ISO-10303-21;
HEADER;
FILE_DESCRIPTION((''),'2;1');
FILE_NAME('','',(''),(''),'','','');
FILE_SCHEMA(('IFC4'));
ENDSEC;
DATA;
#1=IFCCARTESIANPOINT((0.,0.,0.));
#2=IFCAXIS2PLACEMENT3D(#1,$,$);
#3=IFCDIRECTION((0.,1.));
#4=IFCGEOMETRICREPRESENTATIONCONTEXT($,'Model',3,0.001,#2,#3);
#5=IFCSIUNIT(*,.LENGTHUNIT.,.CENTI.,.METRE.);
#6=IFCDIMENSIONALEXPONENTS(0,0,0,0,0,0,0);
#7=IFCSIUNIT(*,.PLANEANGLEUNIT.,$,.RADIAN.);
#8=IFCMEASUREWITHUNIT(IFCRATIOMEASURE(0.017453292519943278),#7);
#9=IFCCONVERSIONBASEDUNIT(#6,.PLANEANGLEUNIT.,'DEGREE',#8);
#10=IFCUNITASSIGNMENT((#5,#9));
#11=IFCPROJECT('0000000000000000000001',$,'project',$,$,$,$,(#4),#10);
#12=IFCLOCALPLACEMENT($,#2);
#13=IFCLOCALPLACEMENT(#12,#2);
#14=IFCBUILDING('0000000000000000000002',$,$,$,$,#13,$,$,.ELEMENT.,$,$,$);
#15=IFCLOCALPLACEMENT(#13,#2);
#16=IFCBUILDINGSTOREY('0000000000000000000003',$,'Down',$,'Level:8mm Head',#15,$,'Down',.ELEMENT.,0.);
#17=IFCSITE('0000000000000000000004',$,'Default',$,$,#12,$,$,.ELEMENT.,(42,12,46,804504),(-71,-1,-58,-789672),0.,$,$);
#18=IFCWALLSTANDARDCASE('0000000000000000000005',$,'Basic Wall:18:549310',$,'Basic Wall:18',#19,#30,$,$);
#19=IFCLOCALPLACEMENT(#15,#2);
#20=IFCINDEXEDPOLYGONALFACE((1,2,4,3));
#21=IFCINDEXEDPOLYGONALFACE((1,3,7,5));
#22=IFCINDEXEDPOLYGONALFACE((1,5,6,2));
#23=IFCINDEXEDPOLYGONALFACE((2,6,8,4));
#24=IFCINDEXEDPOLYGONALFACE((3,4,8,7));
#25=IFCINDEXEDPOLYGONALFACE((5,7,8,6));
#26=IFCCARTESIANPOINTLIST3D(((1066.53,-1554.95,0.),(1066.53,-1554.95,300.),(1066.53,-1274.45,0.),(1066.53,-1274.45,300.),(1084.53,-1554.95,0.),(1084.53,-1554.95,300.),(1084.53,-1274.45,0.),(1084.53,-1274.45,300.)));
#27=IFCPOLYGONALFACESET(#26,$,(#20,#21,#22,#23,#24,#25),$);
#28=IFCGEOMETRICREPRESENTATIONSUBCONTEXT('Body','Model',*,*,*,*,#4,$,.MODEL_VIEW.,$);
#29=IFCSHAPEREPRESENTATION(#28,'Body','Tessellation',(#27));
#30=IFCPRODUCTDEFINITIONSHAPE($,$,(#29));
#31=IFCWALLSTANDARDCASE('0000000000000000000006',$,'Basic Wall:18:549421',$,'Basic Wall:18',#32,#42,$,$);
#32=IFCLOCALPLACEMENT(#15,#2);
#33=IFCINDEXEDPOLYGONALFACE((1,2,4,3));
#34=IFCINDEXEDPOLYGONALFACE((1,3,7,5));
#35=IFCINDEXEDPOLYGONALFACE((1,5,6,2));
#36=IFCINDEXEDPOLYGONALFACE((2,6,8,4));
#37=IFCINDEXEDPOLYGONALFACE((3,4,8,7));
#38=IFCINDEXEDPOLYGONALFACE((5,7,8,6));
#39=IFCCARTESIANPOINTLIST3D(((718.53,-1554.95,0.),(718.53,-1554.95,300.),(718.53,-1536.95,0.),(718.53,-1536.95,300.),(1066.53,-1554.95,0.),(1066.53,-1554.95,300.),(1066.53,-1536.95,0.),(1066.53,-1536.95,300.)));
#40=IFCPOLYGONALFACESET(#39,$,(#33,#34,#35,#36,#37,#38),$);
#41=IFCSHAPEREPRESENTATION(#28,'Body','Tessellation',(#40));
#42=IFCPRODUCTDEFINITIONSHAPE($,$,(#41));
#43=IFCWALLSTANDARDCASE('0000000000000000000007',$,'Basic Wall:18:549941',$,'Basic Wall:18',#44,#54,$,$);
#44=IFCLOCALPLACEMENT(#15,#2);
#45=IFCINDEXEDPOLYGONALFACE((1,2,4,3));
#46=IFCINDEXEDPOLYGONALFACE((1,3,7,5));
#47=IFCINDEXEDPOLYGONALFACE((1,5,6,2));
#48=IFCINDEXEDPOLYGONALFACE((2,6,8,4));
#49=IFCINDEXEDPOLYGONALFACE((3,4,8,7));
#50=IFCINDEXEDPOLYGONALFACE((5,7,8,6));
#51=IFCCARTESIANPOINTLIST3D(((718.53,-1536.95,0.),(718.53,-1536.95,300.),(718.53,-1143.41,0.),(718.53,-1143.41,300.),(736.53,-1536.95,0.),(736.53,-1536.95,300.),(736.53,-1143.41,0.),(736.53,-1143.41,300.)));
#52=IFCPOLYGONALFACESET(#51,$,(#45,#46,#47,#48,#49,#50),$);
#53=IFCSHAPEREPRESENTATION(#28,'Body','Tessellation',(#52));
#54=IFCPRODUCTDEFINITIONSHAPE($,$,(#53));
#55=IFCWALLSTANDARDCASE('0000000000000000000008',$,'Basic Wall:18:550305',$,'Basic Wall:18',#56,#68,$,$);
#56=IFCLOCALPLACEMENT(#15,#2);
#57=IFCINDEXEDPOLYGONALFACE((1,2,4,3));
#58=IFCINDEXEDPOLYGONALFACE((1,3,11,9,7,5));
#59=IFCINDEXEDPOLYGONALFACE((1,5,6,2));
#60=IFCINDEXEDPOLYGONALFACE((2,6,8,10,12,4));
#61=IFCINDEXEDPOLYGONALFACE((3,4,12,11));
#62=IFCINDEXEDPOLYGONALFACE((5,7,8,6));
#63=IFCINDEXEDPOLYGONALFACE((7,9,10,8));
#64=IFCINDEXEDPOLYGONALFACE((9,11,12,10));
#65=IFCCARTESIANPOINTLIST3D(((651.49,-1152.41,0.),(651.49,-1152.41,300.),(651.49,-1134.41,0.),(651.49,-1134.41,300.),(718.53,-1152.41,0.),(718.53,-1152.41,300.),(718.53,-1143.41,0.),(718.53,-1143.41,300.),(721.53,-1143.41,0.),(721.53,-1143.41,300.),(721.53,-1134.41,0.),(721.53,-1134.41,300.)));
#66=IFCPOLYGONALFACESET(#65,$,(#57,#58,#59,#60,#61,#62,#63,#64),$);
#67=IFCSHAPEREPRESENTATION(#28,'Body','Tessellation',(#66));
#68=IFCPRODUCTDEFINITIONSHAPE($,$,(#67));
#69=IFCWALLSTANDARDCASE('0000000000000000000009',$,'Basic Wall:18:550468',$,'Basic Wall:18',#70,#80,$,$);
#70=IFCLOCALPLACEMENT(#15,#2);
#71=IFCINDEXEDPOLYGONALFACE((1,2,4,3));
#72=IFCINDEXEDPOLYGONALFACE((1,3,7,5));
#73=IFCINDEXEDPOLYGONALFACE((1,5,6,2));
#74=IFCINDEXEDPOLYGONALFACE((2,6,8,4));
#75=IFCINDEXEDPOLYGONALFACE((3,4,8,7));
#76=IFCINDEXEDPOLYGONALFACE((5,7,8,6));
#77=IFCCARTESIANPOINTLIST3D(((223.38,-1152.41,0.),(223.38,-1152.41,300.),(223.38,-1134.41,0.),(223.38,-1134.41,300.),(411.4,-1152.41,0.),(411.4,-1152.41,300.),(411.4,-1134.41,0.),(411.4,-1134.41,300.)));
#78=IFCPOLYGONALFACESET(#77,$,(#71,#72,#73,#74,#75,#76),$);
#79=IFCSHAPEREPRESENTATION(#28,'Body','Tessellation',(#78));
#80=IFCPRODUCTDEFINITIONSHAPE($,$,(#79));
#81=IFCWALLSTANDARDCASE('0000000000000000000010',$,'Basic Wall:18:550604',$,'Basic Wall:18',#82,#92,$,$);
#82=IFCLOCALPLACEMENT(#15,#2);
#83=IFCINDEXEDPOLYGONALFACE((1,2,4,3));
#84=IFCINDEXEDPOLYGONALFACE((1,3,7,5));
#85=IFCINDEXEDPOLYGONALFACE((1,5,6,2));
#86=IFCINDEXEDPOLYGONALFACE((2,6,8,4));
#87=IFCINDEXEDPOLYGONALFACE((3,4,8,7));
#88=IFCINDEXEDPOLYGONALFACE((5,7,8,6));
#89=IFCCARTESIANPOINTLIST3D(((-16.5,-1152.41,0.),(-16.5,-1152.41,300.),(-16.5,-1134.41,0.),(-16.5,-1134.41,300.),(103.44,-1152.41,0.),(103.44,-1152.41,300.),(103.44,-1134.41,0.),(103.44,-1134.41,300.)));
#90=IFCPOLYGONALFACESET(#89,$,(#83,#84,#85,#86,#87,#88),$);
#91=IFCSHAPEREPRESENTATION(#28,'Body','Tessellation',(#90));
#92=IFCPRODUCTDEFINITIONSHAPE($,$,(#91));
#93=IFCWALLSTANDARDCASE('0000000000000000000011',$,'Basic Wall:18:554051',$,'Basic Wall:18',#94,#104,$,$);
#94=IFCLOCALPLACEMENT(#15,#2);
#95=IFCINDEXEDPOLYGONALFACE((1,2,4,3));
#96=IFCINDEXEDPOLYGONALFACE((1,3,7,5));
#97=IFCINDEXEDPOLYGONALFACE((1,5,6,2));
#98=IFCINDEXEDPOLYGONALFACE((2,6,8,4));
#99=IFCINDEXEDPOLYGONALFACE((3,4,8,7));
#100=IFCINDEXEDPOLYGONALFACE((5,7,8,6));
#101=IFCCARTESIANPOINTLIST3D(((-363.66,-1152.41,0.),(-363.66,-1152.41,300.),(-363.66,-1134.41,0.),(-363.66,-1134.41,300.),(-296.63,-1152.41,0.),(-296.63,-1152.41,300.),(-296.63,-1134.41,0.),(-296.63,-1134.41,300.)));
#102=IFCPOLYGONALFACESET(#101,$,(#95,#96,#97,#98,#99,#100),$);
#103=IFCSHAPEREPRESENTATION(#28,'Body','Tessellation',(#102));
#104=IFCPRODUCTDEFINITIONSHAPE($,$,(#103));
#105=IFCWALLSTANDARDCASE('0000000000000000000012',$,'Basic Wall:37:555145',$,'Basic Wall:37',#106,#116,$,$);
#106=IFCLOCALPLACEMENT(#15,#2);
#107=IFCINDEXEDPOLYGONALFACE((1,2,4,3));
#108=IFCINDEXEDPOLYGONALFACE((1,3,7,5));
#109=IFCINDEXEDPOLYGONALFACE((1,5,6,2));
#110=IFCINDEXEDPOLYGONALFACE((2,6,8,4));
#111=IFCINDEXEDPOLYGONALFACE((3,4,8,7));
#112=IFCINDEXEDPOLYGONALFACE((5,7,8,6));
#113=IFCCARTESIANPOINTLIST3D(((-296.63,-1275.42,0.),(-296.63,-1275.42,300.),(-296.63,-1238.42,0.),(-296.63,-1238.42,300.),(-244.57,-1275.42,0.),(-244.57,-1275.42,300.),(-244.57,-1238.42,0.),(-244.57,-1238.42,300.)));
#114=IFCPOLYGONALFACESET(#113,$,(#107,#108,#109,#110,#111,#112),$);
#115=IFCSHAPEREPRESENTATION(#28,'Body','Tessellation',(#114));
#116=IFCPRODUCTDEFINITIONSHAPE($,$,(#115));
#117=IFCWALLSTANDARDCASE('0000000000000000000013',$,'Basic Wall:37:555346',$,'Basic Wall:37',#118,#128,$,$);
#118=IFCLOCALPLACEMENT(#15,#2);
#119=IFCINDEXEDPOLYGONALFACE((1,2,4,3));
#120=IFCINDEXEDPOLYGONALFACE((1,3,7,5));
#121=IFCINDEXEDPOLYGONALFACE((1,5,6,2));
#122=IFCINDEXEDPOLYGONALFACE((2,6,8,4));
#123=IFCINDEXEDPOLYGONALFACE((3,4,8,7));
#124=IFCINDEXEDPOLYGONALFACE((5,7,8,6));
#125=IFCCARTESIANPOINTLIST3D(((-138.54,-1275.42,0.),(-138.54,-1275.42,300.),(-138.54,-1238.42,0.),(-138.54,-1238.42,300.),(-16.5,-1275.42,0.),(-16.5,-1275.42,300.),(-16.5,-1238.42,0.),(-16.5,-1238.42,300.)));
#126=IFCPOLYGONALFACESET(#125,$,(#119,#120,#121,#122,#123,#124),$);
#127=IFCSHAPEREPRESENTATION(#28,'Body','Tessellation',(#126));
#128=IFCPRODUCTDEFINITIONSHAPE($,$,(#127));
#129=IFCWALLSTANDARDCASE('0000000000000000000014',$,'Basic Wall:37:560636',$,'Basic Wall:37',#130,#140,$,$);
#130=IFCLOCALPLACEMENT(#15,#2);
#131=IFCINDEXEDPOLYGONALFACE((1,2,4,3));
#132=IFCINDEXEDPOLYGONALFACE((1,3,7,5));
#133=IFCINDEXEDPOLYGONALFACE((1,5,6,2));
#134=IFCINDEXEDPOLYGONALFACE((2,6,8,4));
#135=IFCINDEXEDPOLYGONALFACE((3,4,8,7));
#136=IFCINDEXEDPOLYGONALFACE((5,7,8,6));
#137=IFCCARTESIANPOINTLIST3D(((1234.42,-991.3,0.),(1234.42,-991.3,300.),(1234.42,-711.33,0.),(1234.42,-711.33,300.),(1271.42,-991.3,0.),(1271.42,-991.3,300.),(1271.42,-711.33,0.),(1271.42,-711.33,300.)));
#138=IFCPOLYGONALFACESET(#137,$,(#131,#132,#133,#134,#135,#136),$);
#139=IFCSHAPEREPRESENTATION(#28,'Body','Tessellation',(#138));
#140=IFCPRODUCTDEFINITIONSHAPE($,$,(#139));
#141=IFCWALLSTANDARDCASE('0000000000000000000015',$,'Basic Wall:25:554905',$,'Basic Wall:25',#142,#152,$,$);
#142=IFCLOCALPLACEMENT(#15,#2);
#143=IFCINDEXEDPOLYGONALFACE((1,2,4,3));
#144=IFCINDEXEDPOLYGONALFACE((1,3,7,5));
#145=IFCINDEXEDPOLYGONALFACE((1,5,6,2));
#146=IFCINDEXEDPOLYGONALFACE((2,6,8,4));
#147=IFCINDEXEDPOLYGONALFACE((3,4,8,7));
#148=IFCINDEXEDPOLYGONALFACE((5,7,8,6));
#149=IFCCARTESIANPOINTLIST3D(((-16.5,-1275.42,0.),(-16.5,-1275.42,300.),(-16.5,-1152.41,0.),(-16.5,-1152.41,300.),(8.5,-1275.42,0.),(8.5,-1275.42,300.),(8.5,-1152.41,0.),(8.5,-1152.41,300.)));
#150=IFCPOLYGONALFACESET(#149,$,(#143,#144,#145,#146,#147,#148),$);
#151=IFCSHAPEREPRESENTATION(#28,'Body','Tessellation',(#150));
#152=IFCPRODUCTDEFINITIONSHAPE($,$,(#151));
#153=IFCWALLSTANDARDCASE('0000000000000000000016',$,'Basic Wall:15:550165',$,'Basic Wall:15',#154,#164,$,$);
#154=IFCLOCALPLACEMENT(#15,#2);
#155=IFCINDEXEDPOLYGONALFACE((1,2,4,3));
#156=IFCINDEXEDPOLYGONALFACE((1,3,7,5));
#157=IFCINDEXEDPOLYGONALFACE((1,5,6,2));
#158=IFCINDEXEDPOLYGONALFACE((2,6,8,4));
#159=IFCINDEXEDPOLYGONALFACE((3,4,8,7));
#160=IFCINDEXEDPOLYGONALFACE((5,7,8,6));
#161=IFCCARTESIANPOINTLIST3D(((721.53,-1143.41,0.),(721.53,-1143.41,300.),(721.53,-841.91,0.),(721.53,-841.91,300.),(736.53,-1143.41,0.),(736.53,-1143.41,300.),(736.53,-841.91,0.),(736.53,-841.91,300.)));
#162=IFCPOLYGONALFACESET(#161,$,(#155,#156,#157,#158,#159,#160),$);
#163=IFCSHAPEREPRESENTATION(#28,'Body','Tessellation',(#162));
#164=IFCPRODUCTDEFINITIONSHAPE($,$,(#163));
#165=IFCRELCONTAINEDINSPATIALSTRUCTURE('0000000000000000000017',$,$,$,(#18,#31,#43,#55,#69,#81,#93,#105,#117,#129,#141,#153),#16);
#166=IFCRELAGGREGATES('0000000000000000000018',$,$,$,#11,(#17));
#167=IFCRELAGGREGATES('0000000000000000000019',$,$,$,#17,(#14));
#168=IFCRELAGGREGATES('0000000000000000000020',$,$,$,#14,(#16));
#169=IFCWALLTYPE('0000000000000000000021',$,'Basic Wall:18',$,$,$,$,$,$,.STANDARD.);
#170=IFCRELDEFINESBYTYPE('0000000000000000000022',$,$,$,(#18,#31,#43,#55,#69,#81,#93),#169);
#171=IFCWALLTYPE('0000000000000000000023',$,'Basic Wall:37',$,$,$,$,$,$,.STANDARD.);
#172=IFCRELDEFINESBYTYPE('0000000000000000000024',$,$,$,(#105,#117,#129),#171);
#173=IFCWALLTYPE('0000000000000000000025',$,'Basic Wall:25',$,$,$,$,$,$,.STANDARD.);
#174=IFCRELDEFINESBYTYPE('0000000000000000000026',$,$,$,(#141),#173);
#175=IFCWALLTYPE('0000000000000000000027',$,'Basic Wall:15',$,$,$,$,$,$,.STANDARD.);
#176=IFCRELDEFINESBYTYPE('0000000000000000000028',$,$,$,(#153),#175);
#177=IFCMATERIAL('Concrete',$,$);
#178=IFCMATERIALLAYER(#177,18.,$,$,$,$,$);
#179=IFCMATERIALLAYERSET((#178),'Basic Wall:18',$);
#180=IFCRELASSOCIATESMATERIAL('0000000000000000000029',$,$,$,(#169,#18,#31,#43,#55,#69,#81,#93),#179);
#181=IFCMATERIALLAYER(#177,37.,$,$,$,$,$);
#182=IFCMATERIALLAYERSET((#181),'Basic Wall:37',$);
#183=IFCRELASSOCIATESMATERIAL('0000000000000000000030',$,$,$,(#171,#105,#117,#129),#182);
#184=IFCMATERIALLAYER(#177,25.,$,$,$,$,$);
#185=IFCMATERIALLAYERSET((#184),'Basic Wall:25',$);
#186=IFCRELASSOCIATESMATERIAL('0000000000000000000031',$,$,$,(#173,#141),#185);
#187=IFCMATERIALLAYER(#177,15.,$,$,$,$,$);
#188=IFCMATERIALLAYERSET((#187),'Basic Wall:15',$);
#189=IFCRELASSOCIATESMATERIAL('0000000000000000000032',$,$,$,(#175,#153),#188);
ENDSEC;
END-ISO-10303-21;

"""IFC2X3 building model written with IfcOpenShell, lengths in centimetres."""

from ifc_helpers import new_model, entity, si_unit, converted_unit, direction, frame, frame_2d, origin, place, context, subcontext, project, spatial, polyline, rectangle, outline, extrude, material, layer, layer_set, layer_usage, type_object, element, save


model = new_model("IFC2X3")

# Units and contexts
model_context = context("Model", 3, precision=0.001, world=origin(), true_north=direction((0.0, 1.0)))
body_context = subcontext(model_context, "Body", "Model", "MODEL_VIEW")
ifc_project = project(units=[si_unit("LENGTHUNIT", "METRE", prefix="CENTI"), converted_unit("PLANEANGLEUNIT", "DEGREE", entity("IfcRatioMeasure", 0.017453292519943278), si_unit("PLANEANGLEUNIT", "RADIAN"), dimensions=[0, 0, 0, 0, 0, 0, 0])], contexts=[model_context])

# Site, building, storey
site_placement = place(None, origin())
site = spatial("IfcSite", under=ifc_project, at=site_placement, Name="Default", CompositionType="ELEMENT", RefLatitude=(42, 12, 46, 804504), RefLongitude=(-71, -1, -58, -789672), RefElevation=0.0)
building_placement = place(site_placement, origin())
building = spatial("IfcBuilding", under=site, at=building_placement, CompositionType="ELEMENT")
storey_placement = place(building_placement, origin())
storey = spatial("IfcBuildingStorey", under=building, at=storey_placement, Name="Down", ObjectType="Level:8mm Head", LongName="Down", CompositionType="ELEMENT", Elevation=0.0)

# Walls
ifc_material = material(Name="Concrete")
ifc_layer_1 = layer(ifc_material, 18.0)
ifc_layer_set_1 = layer_set([ifc_layer_1], Name="Basic Wall:18")
wall_type_1 = type_object("IfcWallType", Name="Basic Wall:18", PredefinedType="STANDARD", material=ifc_layer_set_1)
ifc_layer_usage_1 = layer_usage(ifc_layer_set_1, "AXIS2", "POSITIVE", -9.0)
wall_1_placement = place(storey_placement, frame((1075.53, -1274.45, 0.0), z_axis=(0.0, 0.0, 1.0), x_axis=(0.0, -1.0, 0.0)))
element("IfcWallStandardCase", 1, at=wall_1_placement, inside=storey, type_object=wall_type_1, material=ifc_layer_usage_1, Name="Basic Wall:18:549310", ObjectType="Basic Wall:18", context=body_context, shape_type="SweptSolid", body=[
    extrude(rectangle(XDim=280.5, YDim=18.0, at=frame_2d((140.25, 0.0), x_axis=(-1.0, 0.0))), origin(), (0.0, 0.0, 1.0), 300.0),
])
ifc_layer_usage_2 = layer_usage(ifc_layer_set_1, "AXIS2", "NEGATIVE", 9.0)
wall_2_placement = place(storey_placement, frame((1066.53, -1545.95, 0.0), z_axis=(0.0, 0.0, 1.0), x_axis=(-1.0, 0.0, 0.0)))
element("IfcWallStandardCase", 2, at=wall_2_placement, inside=storey, type_object=wall_type_1, material=ifc_layer_usage_2, Name="Basic Wall:18:549421", ObjectType="Basic Wall:18", context=body_context, shape_type="SweptSolid", body=[
    extrude(rectangle(XDim=348.0, YDim=18.0, at=frame_2d((174.0, 0.0), x_axis=(-1.0, 0.0))), origin(), (0.0, 0.0, 1.0), 300.0),
])
ifc_layer_usage_3 = layer_usage(ifc_layer_set_1, "AXIS2", "NEGATIVE", 9.0)
wall_3_placement = place(storey_placement, frame((727.53, -1536.95, 0.0), z_axis=(0.0, 0.0, 1.0), x_axis=(0.0, 1.0, 0.0)))
element("IfcWallStandardCase", 3, at=wall_3_placement, inside=storey, type_object=wall_type_1, material=ifc_layer_usage_3, Name="Basic Wall:18:549941", ObjectType="Basic Wall:18", context=body_context, shape_type="SweptSolid", body=[
    extrude(rectangle(XDim=393.55, YDim=18.0, at=frame_2d((196.77, 0.0), x_axis=(-1.0, 0.0))), origin(), (0.0, 0.0, 1.0), 300.0),
])
ifc_layer_usage_4 = layer_usage(ifc_layer_set_1, "AXIS2", "POSITIVE", -9.0)
wall_4_placement = place(storey_placement, frame((721.53, -1143.41, 0.0), z_axis=(0.0, 0.0, 1.0), x_axis=(-1.0, 0.0, 0.0)))
element("IfcWallStandardCase", 4, at=wall_4_placement, inside=storey, type_object=wall_type_1, material=ifc_layer_usage_4, Name="Basic Wall:18:550305", ObjectType="Basic Wall:18", context=body_context, shape_type="SweptSolid", body=[
    extrude(outline(polyline([(70.04, -9.0), (70.04, 9.0), (3.0, 9.0), (3.0, 0.0), (0.0, 0.0), (0.0, -9.0), (70.04, -9.0)])), origin(), (0.0, 0.0, 1.0), 300.0),
])
ifc_layer_usage_5 = layer_usage(ifc_layer_set_1, "AXIS2", "POSITIVE", -9.0)
wall_5_placement = place(storey_placement, frame((411.4, -1143.41, 0.0), z_axis=(0.0, 0.0, 1.0), x_axis=(-1.0, 0.0, 0.0)))
element("IfcWallStandardCase", 5, at=wall_5_placement, inside=storey, type_object=wall_type_1, material=ifc_layer_usage_5, Name="Basic Wall:18:550468", ObjectType="Basic Wall:18", context=body_context, shape_type="SweptSolid", body=[
    extrude(rectangle(XDim=188.02, YDim=18.0, at=frame_2d((94.01, 0.0), x_axis=(-1.0, 0.0))), origin(), (0.0, 0.0, 1.0), 300.0),
])
ifc_layer_usage_6 = layer_usage(ifc_layer_set_1, "AXIS2", "POSITIVE", -9.0)
wall_6_placement = place(storey_placement, frame((103.44, -1143.41, 0.0), z_axis=(0.0, 0.0, 1.0), x_axis=(-1.0, 0.0, 0.0)))
element("IfcWallStandardCase", 6, at=wall_6_placement, inside=storey, type_object=wall_type_1, material=ifc_layer_usage_6, Name="Basic Wall:18:550604", ObjectType="Basic Wall:18", context=body_context, shape_type="SweptSolid", body=[
    extrude(rectangle(XDim=119.94, YDim=18.0, at=frame_2d((59.97, 0.0), x_axis=(-1.0, 0.0))), origin(), (0.0, 0.0, 1.0), 300.0),
])
ifc_layer_usage_7 = layer_usage(ifc_layer_set_1, "AXIS2", "POSITIVE", -9.0)
wall_7_placement = place(storey_placement, frame((-296.63, -1143.41, 0.0), z_axis=(0.0, 0.0, 1.0), x_axis=(-1.0, 0.0, 0.0)))
element("IfcWallStandardCase", 7, at=wall_7_placement, inside=storey, type_object=wall_type_1, material=ifc_layer_usage_7, Name="Basic Wall:18:554051", ObjectType="Basic Wall:18", context=body_context, shape_type="SweptSolid", body=[
    extrude(rectangle(XDim=67.03, YDim=18.0, at=frame_2d((33.52, 0.0), x_axis=(-1.0, 0.0))), origin(), (0.0, 0.0, 1.0), 300.0),
])
ifc_layer_2 = layer(ifc_material, 37.0)
ifc_layer_set_2 = layer_set([ifc_layer_2], Name="Basic Wall:37")
ifc_layer_usage_8 = layer_usage(ifc_layer_set_2, "AXIS2", "POSITIVE", -18.5)
wall_type_2 = type_object("IfcWallType", Name="Basic Wall:37", PredefinedType="STANDARD", material=ifc_layer_set_2)
wall_8_placement = place(storey_placement, frame((-296.63, -1256.92, 0.0)))
element("IfcWallStandardCase", 8, at=wall_8_placement, inside=storey, type_object=wall_type_2, material=ifc_layer_usage_8, Name="Basic Wall:37:555145", ObjectType="Basic Wall:37", context=body_context, shape_type="SweptSolid", body=[
    extrude(rectangle(XDim=52.06, YDim=37.0, at=frame_2d((26.03, 0.0), x_axis=(-1.0, 0.0))), origin(), (0.0, 0.0, 1.0), 300.0),
])
ifc_layer_usage_9 = layer_usage(ifc_layer_set_2, "AXIS2", "POSITIVE", -18.5)
wall_9_placement = place(storey_placement, frame((-138.54, -1256.92, 0.0)))
element("IfcWallStandardCase", 9, at=wall_9_placement, inside=storey, type_object=wall_type_2, material=ifc_layer_usage_9, Name="Basic Wall:37:555346", ObjectType="Basic Wall:37", context=body_context, shape_type="SweptSolid", body=[
    extrude(rectangle(XDim=122.05, YDim=37.0, at=frame_2d((61.02, 0.0), x_axis=(-1.0, 0.0))), origin(), (0.0, 0.0, 1.0), 300.0),
])
ifc_layer_usage_10 = layer_usage(ifc_layer_set_2, "AXIS2", "POSITIVE", -18.5)
wall_10_placement = place(storey_placement, frame((1252.92, -991.3, 0.0), z_axis=(0.0, 0.0, 1.0), x_axis=(0.0, 1.0, 0.0)))
element("IfcWallStandardCase", 10, at=wall_10_placement, inside=storey, type_object=wall_type_2, material=ifc_layer_usage_10, Name="Basic Wall:37:560636", ObjectType="Basic Wall:37", context=body_context, shape_type="SweptSolid", body=[
    extrude(rectangle(XDim=279.98, YDim=37.0, at=frame_2d((139.99, 0.0), x_axis=(-1.0, 0.0))), origin(), (0.0, 0.0, 1.0), 300.0),
])
ifc_layer_3 = layer(ifc_material, 25.0)
ifc_layer_set_3 = layer_set([ifc_layer_3], Name="Basic Wall:25")
ifc_layer_usage_11 = layer_usage(ifc_layer_set_3, "AXIS2", "POSITIVE", -12.5)
wall_type_3 = type_object("IfcWallType", Name="Basic Wall:25", PredefinedType="STANDARD", material=ifc_layer_set_3)
wall_11_placement = place(storey_placement, frame((-4.0, -1152.41, 0.0), z_axis=(0.0, 0.0, 1.0), x_axis=(0.0, -1.0, 0.0)))
element("IfcWallStandardCase", 11, at=wall_11_placement, inside=storey, type_object=wall_type_3, material=ifc_layer_usage_11, Name="Basic Wall:25:554905", ObjectType="Basic Wall:25", context=body_context, shape_type="SweptSolid", body=[
    extrude(rectangle(XDim=123.02, YDim=25.0, at=frame_2d((61.51, 0.0), x_axis=(-1.0, 0.0))), origin(), (0.0, 0.0, 1.0), 300.0),
])
ifc_layer_4 = layer(ifc_material, 15.0)
ifc_layer_set_4 = layer_set([ifc_layer_4], Name="Basic Wall:15")
ifc_layer_usage_12 = layer_usage(ifc_layer_set_4, "AXIS2", "POSITIVE", -7.5)
wall_type_4 = type_object("IfcWallType", Name="Basic Wall:15", PredefinedType="STANDARD", material=ifc_layer_set_4)
wall_12_placement = place(storey_placement, frame((729.03, -1143.41, 0.0), z_axis=(0.0, 0.0, 1.0), x_axis=(0.0, 1.0, 0.0)))
element("IfcWallStandardCase", 12, at=wall_12_placement, inside=storey, type_object=wall_type_4, material=ifc_layer_usage_12, Name="Basic Wall:15:550165", ObjectType="Basic Wall:15", context=body_context, shape_type="SweptSolid", body=[
    extrude(rectangle(XDim=301.5, YDim=15.0, at=frame_2d((150.75, 0.0), x_axis=(-1.0, 0.0))), origin(), (0.0, 0.0, 1.0), 300.0),
])

save(model, "model.ifc")
